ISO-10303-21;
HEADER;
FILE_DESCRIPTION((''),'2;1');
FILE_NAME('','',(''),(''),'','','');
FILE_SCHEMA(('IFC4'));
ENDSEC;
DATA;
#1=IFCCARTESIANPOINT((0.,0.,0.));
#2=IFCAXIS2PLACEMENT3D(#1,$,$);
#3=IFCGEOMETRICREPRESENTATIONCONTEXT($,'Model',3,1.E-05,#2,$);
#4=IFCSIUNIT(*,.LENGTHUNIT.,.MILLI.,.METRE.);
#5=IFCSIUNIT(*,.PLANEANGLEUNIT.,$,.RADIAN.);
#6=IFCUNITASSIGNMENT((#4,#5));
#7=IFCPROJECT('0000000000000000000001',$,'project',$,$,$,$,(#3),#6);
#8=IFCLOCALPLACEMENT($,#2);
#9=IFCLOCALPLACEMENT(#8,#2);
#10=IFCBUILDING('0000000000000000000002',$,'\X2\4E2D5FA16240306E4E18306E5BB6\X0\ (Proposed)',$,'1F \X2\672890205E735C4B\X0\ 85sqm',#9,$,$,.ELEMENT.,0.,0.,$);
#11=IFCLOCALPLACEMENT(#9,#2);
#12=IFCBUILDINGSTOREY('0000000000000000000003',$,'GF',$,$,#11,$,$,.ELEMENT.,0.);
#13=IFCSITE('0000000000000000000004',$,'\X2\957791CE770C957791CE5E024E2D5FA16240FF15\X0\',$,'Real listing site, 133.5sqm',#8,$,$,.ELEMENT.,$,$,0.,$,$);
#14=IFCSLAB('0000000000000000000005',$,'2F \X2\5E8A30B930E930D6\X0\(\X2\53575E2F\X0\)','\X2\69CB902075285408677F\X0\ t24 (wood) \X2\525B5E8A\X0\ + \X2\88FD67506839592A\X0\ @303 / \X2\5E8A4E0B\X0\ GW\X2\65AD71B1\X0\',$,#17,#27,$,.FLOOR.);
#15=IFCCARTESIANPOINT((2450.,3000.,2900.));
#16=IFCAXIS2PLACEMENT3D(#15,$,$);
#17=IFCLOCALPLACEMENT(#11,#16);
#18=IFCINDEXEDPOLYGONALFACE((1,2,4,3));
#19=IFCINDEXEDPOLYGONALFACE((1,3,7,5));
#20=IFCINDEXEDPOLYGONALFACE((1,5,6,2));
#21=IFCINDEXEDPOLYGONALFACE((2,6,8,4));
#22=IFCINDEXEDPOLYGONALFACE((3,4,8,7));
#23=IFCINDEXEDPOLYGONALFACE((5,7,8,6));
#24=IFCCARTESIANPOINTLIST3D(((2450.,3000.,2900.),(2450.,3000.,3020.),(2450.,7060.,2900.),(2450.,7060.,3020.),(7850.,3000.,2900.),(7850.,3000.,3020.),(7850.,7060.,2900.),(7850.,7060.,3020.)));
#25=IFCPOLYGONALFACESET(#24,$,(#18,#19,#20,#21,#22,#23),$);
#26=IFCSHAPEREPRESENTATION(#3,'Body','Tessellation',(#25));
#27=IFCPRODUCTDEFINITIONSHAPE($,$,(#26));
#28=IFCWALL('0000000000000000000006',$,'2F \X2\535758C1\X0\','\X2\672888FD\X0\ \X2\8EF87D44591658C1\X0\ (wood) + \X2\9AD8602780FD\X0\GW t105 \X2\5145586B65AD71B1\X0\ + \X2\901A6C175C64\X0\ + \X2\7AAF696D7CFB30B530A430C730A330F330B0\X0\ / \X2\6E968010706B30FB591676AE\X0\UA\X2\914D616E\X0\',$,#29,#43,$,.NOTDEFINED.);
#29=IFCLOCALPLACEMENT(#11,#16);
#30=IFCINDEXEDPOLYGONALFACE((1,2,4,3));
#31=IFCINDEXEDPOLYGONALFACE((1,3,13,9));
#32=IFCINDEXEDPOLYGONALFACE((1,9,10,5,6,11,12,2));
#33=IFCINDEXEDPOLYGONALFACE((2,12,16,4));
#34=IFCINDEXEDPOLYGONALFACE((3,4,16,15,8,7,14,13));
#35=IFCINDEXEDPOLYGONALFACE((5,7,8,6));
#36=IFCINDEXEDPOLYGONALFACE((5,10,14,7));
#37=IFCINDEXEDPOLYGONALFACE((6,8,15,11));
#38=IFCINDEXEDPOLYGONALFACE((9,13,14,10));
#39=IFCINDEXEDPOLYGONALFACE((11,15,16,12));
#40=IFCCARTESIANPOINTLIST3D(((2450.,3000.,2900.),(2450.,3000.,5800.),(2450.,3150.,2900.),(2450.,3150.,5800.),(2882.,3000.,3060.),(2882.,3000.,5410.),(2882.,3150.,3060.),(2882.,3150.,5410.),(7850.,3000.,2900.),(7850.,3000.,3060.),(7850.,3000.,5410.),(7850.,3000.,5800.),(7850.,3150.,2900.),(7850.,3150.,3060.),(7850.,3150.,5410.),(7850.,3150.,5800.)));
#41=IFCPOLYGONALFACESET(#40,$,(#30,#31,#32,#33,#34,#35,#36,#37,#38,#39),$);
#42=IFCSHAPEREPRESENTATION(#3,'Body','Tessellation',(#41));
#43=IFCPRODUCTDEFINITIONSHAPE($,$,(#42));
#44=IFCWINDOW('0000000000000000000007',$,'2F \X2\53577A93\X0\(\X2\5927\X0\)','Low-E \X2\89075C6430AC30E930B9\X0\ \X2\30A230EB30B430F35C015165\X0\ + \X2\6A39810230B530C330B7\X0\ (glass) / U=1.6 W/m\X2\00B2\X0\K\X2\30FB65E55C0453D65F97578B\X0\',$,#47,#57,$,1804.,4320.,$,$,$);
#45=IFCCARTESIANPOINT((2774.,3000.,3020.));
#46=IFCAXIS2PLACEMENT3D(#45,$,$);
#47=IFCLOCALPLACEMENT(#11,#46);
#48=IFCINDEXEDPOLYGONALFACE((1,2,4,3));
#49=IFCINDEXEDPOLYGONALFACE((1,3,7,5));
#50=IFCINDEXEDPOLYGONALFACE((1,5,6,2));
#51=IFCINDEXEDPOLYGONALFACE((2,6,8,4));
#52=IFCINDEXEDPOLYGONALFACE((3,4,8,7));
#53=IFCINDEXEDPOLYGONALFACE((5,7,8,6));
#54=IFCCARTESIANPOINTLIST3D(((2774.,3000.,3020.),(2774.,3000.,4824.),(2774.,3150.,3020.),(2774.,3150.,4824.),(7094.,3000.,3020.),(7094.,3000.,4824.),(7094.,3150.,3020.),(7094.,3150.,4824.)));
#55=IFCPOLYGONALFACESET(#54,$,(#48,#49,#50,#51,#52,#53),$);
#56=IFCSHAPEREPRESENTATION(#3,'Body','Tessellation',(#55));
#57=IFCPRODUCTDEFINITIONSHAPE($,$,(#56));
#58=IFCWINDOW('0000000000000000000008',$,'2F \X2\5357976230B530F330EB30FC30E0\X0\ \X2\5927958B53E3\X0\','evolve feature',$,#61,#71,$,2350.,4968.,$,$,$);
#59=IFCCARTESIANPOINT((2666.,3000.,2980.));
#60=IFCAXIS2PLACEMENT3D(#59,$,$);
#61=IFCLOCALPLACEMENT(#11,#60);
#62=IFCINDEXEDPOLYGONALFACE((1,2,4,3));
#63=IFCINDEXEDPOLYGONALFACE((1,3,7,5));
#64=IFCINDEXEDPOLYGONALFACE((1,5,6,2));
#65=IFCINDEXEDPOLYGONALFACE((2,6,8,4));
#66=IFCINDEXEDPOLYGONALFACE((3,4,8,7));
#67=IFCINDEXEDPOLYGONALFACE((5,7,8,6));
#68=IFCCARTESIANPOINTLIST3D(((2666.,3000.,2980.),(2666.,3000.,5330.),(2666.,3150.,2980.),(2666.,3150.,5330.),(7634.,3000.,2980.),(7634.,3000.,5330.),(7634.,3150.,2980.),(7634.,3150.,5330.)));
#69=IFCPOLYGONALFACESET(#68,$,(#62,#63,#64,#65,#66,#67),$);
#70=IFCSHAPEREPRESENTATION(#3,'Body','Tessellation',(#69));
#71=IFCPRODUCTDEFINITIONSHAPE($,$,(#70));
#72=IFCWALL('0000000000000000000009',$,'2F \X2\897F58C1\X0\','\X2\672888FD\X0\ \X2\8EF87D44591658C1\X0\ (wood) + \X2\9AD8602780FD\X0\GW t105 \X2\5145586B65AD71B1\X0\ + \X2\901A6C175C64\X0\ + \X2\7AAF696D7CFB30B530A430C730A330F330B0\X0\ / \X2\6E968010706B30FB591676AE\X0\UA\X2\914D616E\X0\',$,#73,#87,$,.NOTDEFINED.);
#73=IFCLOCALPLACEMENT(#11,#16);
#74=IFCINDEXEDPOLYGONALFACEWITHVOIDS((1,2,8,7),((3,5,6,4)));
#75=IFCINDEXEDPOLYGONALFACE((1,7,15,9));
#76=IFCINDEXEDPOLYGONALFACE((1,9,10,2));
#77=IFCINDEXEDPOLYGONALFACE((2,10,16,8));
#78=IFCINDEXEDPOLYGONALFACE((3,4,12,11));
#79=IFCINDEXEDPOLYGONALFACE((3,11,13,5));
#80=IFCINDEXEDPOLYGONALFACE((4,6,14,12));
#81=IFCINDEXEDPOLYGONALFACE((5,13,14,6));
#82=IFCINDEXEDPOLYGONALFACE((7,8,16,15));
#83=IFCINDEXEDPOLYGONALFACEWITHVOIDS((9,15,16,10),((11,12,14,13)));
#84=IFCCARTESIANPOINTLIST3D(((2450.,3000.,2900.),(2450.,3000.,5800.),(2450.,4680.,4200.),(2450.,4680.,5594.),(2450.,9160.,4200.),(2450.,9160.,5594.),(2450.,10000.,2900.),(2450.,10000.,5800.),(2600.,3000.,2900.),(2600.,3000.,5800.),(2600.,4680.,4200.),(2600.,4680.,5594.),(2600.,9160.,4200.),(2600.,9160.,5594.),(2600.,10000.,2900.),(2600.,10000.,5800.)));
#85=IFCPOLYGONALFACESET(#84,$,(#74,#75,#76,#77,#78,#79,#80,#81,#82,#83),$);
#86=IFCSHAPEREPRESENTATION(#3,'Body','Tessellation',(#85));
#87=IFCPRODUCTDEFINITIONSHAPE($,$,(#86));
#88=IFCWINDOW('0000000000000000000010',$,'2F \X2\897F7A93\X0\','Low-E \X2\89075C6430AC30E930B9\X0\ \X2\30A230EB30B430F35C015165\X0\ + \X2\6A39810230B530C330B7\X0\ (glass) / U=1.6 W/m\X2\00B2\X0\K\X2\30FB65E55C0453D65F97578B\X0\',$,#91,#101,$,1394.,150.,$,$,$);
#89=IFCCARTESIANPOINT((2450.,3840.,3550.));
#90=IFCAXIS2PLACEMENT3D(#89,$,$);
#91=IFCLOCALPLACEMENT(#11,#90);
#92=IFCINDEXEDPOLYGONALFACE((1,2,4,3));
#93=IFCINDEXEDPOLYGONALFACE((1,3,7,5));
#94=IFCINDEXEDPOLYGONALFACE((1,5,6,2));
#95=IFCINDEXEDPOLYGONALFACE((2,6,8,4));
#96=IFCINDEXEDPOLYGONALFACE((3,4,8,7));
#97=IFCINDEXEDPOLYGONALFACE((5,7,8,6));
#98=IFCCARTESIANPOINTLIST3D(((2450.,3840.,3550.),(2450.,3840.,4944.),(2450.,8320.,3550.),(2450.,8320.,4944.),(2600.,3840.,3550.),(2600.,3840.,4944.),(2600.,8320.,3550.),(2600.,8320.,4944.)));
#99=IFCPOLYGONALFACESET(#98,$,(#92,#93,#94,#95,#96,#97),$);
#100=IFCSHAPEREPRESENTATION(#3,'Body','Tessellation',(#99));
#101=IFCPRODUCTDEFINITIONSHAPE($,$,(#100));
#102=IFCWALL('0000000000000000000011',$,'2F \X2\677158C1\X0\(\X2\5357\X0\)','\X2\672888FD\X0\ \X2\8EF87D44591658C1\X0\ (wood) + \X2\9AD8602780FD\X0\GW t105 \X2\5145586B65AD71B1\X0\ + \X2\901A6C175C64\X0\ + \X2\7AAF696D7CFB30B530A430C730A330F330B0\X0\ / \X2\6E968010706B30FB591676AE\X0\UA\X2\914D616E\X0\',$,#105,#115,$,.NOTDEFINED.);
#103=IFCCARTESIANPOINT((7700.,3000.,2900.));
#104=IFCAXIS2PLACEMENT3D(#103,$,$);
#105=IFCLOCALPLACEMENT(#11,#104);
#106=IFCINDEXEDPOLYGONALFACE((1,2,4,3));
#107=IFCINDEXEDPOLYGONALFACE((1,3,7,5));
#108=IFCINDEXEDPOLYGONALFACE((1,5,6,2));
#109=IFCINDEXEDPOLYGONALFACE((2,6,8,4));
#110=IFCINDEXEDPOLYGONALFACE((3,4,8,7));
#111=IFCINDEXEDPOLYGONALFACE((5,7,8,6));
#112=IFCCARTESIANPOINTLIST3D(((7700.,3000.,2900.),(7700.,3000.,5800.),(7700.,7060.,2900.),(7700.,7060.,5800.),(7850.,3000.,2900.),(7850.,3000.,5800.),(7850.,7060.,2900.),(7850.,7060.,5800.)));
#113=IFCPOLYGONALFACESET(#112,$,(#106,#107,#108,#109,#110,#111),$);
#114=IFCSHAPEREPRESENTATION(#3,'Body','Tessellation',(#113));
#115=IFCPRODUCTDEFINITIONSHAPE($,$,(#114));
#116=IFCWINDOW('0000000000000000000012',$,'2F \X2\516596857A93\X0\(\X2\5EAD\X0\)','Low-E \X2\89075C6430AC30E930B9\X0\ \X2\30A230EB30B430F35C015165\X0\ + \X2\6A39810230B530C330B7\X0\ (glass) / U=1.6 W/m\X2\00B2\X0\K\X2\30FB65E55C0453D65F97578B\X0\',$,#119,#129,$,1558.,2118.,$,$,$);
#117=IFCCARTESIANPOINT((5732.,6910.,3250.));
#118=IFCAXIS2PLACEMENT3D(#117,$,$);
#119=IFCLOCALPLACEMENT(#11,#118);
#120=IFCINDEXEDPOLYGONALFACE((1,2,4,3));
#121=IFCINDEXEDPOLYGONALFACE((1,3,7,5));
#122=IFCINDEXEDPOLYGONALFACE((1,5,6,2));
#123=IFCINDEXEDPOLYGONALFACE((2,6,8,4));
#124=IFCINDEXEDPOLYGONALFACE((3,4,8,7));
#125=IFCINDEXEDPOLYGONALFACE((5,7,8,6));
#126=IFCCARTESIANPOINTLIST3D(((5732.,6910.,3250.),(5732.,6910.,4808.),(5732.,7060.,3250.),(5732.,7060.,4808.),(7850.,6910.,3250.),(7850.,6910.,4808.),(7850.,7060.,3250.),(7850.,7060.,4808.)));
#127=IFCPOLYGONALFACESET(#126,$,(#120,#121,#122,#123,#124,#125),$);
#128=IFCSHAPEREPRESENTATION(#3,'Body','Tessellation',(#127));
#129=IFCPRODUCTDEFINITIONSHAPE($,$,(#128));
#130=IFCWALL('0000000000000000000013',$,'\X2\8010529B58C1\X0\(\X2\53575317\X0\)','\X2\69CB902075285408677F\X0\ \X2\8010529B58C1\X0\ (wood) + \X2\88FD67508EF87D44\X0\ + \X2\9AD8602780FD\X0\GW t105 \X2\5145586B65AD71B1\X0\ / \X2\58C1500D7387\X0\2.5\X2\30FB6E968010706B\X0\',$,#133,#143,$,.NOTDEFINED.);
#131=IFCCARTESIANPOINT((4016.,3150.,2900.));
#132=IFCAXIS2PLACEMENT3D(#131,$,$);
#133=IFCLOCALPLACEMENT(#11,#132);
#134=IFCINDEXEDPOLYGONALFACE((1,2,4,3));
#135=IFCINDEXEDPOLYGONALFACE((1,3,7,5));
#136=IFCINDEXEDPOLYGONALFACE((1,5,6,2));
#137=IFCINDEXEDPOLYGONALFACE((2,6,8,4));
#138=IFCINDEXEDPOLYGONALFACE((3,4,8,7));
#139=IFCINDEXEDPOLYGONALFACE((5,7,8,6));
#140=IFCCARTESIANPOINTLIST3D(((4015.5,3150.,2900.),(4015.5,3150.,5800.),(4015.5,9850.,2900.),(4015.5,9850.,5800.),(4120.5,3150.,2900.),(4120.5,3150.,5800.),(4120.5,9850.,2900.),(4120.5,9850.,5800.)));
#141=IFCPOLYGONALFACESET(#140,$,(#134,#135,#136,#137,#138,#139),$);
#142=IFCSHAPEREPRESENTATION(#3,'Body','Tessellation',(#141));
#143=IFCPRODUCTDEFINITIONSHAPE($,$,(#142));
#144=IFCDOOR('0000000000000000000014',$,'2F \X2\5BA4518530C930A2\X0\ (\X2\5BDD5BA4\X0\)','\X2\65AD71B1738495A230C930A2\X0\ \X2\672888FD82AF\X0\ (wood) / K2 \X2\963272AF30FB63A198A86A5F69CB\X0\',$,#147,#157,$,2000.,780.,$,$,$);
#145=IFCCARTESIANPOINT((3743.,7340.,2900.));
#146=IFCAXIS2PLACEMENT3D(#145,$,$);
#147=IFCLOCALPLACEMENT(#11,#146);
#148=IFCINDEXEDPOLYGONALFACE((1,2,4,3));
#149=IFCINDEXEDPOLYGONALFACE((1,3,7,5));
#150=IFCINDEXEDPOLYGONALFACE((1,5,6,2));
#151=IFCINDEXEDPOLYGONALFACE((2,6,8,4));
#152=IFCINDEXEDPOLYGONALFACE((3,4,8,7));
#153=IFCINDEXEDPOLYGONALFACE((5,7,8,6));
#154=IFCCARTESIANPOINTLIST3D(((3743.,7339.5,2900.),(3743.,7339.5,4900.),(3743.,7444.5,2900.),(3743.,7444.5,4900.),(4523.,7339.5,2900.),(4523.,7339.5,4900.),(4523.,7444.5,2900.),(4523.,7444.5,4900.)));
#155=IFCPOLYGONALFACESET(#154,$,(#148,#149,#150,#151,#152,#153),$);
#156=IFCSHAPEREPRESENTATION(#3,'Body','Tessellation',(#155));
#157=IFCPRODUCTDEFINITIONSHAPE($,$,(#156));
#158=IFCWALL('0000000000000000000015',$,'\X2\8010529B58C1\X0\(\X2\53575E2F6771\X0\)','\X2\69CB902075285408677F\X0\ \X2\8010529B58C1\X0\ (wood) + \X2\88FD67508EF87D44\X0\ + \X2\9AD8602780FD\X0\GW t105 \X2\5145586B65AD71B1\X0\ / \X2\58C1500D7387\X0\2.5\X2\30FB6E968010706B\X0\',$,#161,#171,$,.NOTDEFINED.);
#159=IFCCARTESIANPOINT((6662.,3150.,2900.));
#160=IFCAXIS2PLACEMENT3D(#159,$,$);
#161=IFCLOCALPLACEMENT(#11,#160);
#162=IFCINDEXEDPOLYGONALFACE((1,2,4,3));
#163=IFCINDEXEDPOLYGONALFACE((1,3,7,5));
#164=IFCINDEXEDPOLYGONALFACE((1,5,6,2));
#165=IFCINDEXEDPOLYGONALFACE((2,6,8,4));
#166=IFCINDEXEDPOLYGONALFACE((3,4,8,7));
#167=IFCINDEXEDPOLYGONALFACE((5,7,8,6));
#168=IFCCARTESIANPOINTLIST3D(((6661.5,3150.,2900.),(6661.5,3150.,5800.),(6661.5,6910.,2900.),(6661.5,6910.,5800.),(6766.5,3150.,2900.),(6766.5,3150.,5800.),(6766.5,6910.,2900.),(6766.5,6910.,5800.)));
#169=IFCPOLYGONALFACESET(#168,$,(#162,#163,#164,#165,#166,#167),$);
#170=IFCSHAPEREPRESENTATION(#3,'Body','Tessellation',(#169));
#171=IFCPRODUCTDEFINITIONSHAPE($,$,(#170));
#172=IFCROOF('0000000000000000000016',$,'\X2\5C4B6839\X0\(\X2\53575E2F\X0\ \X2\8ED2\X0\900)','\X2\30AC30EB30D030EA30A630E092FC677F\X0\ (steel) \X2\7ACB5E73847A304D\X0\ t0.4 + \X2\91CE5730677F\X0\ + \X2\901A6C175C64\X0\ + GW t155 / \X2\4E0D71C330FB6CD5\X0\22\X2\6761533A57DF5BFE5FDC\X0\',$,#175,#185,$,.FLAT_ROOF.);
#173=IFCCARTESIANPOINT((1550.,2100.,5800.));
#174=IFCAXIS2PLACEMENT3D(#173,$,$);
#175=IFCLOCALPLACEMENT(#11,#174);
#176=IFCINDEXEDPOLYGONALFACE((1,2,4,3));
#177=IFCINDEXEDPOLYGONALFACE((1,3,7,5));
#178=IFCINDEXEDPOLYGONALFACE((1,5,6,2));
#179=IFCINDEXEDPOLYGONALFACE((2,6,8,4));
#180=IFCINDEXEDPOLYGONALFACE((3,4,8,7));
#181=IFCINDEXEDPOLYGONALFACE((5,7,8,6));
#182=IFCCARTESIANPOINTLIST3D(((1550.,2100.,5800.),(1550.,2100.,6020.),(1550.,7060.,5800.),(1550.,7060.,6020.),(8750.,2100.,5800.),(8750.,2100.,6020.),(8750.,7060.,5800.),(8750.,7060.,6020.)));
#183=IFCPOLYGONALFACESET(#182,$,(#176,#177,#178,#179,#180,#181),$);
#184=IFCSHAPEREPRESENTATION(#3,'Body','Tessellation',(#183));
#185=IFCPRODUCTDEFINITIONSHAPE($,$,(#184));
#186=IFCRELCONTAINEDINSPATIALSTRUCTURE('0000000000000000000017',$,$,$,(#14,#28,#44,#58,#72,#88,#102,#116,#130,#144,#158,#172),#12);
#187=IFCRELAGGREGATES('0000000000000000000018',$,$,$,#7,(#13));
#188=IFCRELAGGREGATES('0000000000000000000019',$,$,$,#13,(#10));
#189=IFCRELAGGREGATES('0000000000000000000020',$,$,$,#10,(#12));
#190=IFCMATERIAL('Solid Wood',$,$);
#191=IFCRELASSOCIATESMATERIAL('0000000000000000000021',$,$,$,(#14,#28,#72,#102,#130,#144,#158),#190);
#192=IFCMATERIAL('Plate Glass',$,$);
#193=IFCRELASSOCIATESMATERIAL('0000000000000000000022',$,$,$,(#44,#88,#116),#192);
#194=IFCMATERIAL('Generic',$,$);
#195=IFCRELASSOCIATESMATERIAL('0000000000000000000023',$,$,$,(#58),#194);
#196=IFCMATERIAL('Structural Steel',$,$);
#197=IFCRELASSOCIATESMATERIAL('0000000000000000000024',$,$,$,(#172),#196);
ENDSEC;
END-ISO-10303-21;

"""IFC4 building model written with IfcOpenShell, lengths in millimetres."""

from ifc_helpers import new_model, si_unit, frame, frame_2d, origin, place, context, project, spatial, rectangle, extrude, material, element, fill, save


model = new_model("IFC4")

# Units and contexts
model_context = context("Model", 3, precision=1e-05, world=origin())
ifc_project = project(units=[si_unit("LENGTHUNIT", "METRE", prefix="MILLI"), si_unit("PLANEANGLEUNIT", "RADIAN")], contexts=[model_context])

# Site, building, storey
site_placement = place(None, origin())
site = spatial("IfcSite", under=ifc_project, at=site_placement, Name="長野県長野市中御所５", ObjectType="Real listing site, 133.5sqm", CompositionType="ELEMENT", RefElevation=0.0)
building_placement = place(site_placement, origin())
building = spatial("IfcBuilding", under=site, at=building_placement, Name="中御所の丘の家 (Proposed)", ObjectType="1F 木造平屋 85sqm", CompositionType="ELEMENT", ElevationOfRefHeight=0.0, ElevationOfTerrain=0.0)
storey_placement = place(building_placement, origin())
storey = spatial("IfcBuildingStorey", under=building, at=storey_placement, Name="GF", CompositionType="ELEMENT", Elevation=0.0)

# Slab
ifc_material_1 = material(Name="Solid Wood")
slab_placement = place(storey_placement, frame((2450.0, 3000.0, 2900.0)))
element("IfcSlab", 1, at=slab_placement, inside=storey, material=ifc_material_1, Name="2F 床スラブ(南帯)", Description="構造用合板 t24 (wood) 剛床 + 製材根太 @303 / 床下 GW断熱", PredefinedType="FLOOR", context=model_context, shape_type="SweptSolid", body=[
    extrude(rectangle(XDim=5400.0, YDim=4060.0, at=frame_2d((2700.0, 2030.0))), frame((2450.0, 3000.0, 2900.0)), (0.0, 0.0, 1.0), 120.0),
])

# Wall, openings, windows
wall_1_placement = place(storey_placement, frame((2450.0, 3000.0, 2900.0)))
wall_1 = element("IfcWall", 2, at=wall_1_placement, inside=storey, material=ifc_material_1, Name="2F 南壁", Description="木製 軸組外壁 (wood) + 高性能GW t105 充填断熱 + 通気層 + 窯業系サイディング / 準耐火・外皮UA配慮", PredefinedType="NOTDEFINED", context=model_context, shape_type="SweptSolid", body=[
    extrude(rectangle(XDim=5400.0, YDim=150.0, at=frame_2d((2700.0, 75.0))), frame((2450.0, 3000.0, 2900.0)), (0.0, 0.0, 1.0), 2900.0),
])
opening_1_placement = place(storey_placement, frame((2774.0, 3000.0, 3020.0)))
opening_1 = element("IfcOpeningElement", 3, at=opening_1_placement, cuts=wall_1, PredefinedType="NOTDEFINED", context=model_context, shape_type="SweptSolid", body=[
    extrude(rectangle(XDim=4320.0, YDim=150.0, at=frame_2d((2160.0, 75.0))), frame((2774.0, 3000.0, 3020.0)), (0.0, 0.0, 1.0), 1804.0),
])
opening_2_placement = place(storey_placement, frame((2666.0, 3000.0, 2980.0)))
opening_2 = element("IfcOpeningElement", 4, at=opening_2_placement, cuts=wall_1, PredefinedType="NOTDEFINED", context=model_context, shape_type="SweptSolid", body=[
    extrude(rectangle(XDim=4968.0, YDim=150.0, at=frame_2d((2484.0, 75.0))), frame((2666.0, 3000.0, 2980.0)), (0.0, 0.0, 1.0), 2350.0),
])
ifc_material_2 = material(Name="Plate Glass")
window_1_placement = place(storey_placement, frame((2774.0, 3000.0, 3020.0)))
window_1 = element("IfcWindow", 5, at=window_1_placement, inside=storey, material=ifc_material_2, Name="2F 南窓(大)", Description="Low-E 複層ガラス アルゴン封入 + 樹脂サッシ (glass) / U=1.6 W/m²K・日射取得型", OverallHeight=1804.0, OverallWidth=4320.0, context=model_context, shape_type="SweptSolid", body=[
    extrude(rectangle(XDim=4320.0, YDim=150.0, at=frame_2d((2160.0, 75.0))), frame((2774.0, 3000.0, 3020.0)), (0.0, 0.0, 1.0), 1804.0),
])
fill(opening_1, window_1)
ifc_material_3 = material(Name="Generic")
window_2_placement = place(storey_placement, frame((2666.0, 3000.0, 2980.0)))
window_2 = element("IfcWindow", 6, at=window_2_placement, inside=storey, material=ifc_material_3, Name="2F 南面サンルーム 大開口", Description="evolve feature", OverallHeight=2350.0, OverallWidth=4968.0, context=model_context, shape_type="SweptSolid", body=[
    extrude(rectangle(XDim=4968.0, YDim=150.0, at=frame_2d((2484.0, 75.0))), frame((2666.0, 3000.0, 2980.0)), (0.0, 0.0, 1.0), 2350.0),
])
fill(opening_2, window_2)

# Walls, openings, windows
wall_2_placement = place(storey_placement, frame((2450.0, 3000.0, 2900.0)))
wall_2 = element("IfcWall", 7, at=wall_2_placement, inside=storey, material=ifc_material_1, Name="2F 西壁", Description="木製 軸組外壁 (wood) + 高性能GW t105 充填断熱 + 通気層 + 窯業系サイディング / 準耐火・外皮UA配慮", PredefinedType="NOTDEFINED", context=model_context, shape_type="SweptSolid", body=[
    extrude(rectangle(XDim=150.0, YDim=7000.0, at=frame_2d((75.0, 3500.0))), frame((2450.0, 3000.0, 2900.0)), (0.0, 0.0, 1.0), 2900.0),
])
opening_3_placement = place(storey_placement, frame((2450.0, 3840.0, 3550.0)))
opening_3 = element("IfcOpeningElement", 8, at=opening_3_placement, cuts=wall_2, PredefinedType="NOTDEFINED", context=model_context, shape_type="SweptSolid", body=[
    extrude(rectangle(XDim=150.0, YDim=4480.0, at=frame_2d((75.0, 2240.0))), frame((2450.0, 3840.0, 3550.0)), (0.0, 0.0, 1.0), 1394.0),
])
window_3_placement = place(storey_placement, frame((2450.0, 3840.0, 3550.0)))
window_3 = element("IfcWindow", 9, at=window_3_placement, inside=storey, material=ifc_material_2, Name="2F 西窓", Description="Low-E 複層ガラス アルゴン封入 + 樹脂サッシ (glass) / U=1.6 W/m²K・日射取得型", OverallHeight=1394.0, OverallWidth=150.0, context=model_context, shape_type="SweptSolid", body=[
    extrude(rectangle(XDim=150.0, YDim=4480.0, at=frame_2d((75.0, 2240.0))), frame((2450.0, 3840.0, 3550.0)), (0.0, 0.0, 1.0), 1394.0),
])
fill(opening_3, window_3)
wall_3_placement = place(storey_placement, frame((7700.0, 3000.0, 2900.0)))
wall_3 = element("IfcWall", 10, at=wall_3_placement, inside=storey, material=ifc_material_1, Name="2F 東壁(南)", Description="木製 軸組外壁 (wood) + 高性能GW t105 充填断熱 + 通気層 + 窯業系サイディング / 準耐火・外皮UA配慮", PredefinedType="NOTDEFINED", context=model_context, shape_type="SweptSolid", body=[
    extrude(rectangle(XDim=150.0, YDim=4060.0, at=frame_2d((75.0, 2030.0))), frame((7700.0, 3000.0, 2900.0)), (0.0, 0.0, 1.0), 2900.0),
])
opening_4_placement = place(storey_placement, frame((5732.0, 6910.0, 3250.0)))
opening_4 = element("IfcOpeningElement", 11, at=opening_4_placement, cuts=wall_3, PredefinedType="NOTDEFINED", context=model_context, shape_type="SweptSolid", body=[
    extrude(rectangle(XDim=2118.0, YDim=150.0, at=frame_2d((1059.0, 75.0))), frame((5732.0, 6910.0, 3250.0)), (0.0, 0.0, 1.0), 1558.0),
])
window_4_placement = place(storey_placement, frame((5732.0, 6910.0, 3250.0)))
window_4 = element("IfcWindow", 12, at=window_4_placement, inside=storey, material=ifc_material_2, Name="2F 入隅窓(庭)", Description="Low-E 複層ガラス アルゴン封入 + 樹脂サッシ (glass) / U=1.6 W/m²K・日射取得型", OverallHeight=1558.0, OverallWidth=2118.0, context=model_context, shape_type="SweptSolid", body=[
    extrude(rectangle(XDim=2118.0, YDim=150.0, at=frame_2d((1059.0, 75.0))), frame((5732.0, 6910.0, 3250.0)), (0.0, 0.0, 1.0), 1558.0),
])
fill(opening_4, window_4)

# Wall, opening, door
wall_4_placement = place(storey_placement, frame((4016.0, 3150.0, 2900.0)))
wall_4 = element("IfcWall", 13, at=wall_4_placement, inside=storey, material=ifc_material_1, Name="耐力壁(南北)", Description="構造用合板 耐力壁 (wood) + 製材軸組 + 高性能GW t105 充填断熱 / 壁倍率2.5・準耐火", PredefinedType="NOTDEFINED", context=model_context, shape_type="SweptSolid", body=[
    extrude(rectangle(XDim=105.0, YDim=6700.0, at=frame_2d((52.0, 3350.0))), frame((4016.0, 3150.0, 2900.0)), (0.0, 0.0, 1.0), 2900.0),
])
opening_5_placement = place(storey_placement, frame((3743.0, 7340.0, 2900.0)))
opening_5 = element("IfcOpeningElement", 14, at=opening_5_placement, cuts=wall_4, PredefinedType="NOTDEFINED", context=model_context, shape_type="SweptSolid", body=[
    extrude(rectangle(XDim=780.0, YDim=105.0, at=frame_2d((390.0, 52.0))), frame((3743.0, 7340.0, 2900.0)), (0.0, 0.0, 1.0), 2000.0),
])
door_placement = place(storey_placement, frame((3743.0, 7340.0, 2900.0)))
door = element("IfcDoor", 15, at=door_placement, inside=storey, material=ifc_material_1, Name="2F 室内ドア (寝室)", Description="断熱玄関ドア 木製芯 (wood) / K2 防犯・採風機構", OverallHeight=2000.0, OverallWidth=780.0, context=model_context, shape_type="SweptSolid", body=[
    extrude(rectangle(XDim=780.0, YDim=105.0, at=frame_2d((390.0, 52.0))), frame((3743.0, 7340.0, 2900.0)), (0.0, 0.0, 1.0), 2000.0),
])
fill(opening_5, door)

# Wall
wall_5_placement = place(storey_placement, frame((6662.0, 3150.0, 2900.0)))
element("IfcWall", 16, at=wall_5_placement, inside=storey, material=ifc_material_1, Name="耐力壁(南帯東)", Description="構造用合板 耐力壁 (wood) + 製材軸組 + 高性能GW t105 充填断熱 / 壁倍率2.5・準耐火", PredefinedType="NOTDEFINED", context=model_context, shape_type="SweptSolid", body=[
    extrude(rectangle(XDim=105.0, YDim=3760.0, at=frame_2d((52.0, 1880.0))), frame((6662.0, 3150.0, 2900.0)), (0.0, 0.0, 1.0), 2900.0),
])

# Roof
ifc_material_4 = material(Name="Structural Steel")
for number, where, name in (
    (17, (1550.0, 2100.0, 5800.0), "屋根(南帯 軒900)"),
):
    element("IfcRoof", number, at=place(storey_placement, frame(where)), inside=storey, material=ifc_material_4, Name=name, Description="ガルバリウム鋼板 (steel) 立平葺き t0.4 + 野地板 + 通気層 + GW t155 / 不燃・法22条区域対応", PredefinedType="FLAT_ROOF", context=model_context, shape_type="SweptSolid", body=[
        extrude(rectangle(XDim=7200.0, YDim=4960.0, at=frame_2d((3600.0, 2480.0))), frame((1550.0, 2100.0, 5800.0)), (0.0, 0.0, 1.0), 220.0),
    ])

save(model, "model.ifc")
